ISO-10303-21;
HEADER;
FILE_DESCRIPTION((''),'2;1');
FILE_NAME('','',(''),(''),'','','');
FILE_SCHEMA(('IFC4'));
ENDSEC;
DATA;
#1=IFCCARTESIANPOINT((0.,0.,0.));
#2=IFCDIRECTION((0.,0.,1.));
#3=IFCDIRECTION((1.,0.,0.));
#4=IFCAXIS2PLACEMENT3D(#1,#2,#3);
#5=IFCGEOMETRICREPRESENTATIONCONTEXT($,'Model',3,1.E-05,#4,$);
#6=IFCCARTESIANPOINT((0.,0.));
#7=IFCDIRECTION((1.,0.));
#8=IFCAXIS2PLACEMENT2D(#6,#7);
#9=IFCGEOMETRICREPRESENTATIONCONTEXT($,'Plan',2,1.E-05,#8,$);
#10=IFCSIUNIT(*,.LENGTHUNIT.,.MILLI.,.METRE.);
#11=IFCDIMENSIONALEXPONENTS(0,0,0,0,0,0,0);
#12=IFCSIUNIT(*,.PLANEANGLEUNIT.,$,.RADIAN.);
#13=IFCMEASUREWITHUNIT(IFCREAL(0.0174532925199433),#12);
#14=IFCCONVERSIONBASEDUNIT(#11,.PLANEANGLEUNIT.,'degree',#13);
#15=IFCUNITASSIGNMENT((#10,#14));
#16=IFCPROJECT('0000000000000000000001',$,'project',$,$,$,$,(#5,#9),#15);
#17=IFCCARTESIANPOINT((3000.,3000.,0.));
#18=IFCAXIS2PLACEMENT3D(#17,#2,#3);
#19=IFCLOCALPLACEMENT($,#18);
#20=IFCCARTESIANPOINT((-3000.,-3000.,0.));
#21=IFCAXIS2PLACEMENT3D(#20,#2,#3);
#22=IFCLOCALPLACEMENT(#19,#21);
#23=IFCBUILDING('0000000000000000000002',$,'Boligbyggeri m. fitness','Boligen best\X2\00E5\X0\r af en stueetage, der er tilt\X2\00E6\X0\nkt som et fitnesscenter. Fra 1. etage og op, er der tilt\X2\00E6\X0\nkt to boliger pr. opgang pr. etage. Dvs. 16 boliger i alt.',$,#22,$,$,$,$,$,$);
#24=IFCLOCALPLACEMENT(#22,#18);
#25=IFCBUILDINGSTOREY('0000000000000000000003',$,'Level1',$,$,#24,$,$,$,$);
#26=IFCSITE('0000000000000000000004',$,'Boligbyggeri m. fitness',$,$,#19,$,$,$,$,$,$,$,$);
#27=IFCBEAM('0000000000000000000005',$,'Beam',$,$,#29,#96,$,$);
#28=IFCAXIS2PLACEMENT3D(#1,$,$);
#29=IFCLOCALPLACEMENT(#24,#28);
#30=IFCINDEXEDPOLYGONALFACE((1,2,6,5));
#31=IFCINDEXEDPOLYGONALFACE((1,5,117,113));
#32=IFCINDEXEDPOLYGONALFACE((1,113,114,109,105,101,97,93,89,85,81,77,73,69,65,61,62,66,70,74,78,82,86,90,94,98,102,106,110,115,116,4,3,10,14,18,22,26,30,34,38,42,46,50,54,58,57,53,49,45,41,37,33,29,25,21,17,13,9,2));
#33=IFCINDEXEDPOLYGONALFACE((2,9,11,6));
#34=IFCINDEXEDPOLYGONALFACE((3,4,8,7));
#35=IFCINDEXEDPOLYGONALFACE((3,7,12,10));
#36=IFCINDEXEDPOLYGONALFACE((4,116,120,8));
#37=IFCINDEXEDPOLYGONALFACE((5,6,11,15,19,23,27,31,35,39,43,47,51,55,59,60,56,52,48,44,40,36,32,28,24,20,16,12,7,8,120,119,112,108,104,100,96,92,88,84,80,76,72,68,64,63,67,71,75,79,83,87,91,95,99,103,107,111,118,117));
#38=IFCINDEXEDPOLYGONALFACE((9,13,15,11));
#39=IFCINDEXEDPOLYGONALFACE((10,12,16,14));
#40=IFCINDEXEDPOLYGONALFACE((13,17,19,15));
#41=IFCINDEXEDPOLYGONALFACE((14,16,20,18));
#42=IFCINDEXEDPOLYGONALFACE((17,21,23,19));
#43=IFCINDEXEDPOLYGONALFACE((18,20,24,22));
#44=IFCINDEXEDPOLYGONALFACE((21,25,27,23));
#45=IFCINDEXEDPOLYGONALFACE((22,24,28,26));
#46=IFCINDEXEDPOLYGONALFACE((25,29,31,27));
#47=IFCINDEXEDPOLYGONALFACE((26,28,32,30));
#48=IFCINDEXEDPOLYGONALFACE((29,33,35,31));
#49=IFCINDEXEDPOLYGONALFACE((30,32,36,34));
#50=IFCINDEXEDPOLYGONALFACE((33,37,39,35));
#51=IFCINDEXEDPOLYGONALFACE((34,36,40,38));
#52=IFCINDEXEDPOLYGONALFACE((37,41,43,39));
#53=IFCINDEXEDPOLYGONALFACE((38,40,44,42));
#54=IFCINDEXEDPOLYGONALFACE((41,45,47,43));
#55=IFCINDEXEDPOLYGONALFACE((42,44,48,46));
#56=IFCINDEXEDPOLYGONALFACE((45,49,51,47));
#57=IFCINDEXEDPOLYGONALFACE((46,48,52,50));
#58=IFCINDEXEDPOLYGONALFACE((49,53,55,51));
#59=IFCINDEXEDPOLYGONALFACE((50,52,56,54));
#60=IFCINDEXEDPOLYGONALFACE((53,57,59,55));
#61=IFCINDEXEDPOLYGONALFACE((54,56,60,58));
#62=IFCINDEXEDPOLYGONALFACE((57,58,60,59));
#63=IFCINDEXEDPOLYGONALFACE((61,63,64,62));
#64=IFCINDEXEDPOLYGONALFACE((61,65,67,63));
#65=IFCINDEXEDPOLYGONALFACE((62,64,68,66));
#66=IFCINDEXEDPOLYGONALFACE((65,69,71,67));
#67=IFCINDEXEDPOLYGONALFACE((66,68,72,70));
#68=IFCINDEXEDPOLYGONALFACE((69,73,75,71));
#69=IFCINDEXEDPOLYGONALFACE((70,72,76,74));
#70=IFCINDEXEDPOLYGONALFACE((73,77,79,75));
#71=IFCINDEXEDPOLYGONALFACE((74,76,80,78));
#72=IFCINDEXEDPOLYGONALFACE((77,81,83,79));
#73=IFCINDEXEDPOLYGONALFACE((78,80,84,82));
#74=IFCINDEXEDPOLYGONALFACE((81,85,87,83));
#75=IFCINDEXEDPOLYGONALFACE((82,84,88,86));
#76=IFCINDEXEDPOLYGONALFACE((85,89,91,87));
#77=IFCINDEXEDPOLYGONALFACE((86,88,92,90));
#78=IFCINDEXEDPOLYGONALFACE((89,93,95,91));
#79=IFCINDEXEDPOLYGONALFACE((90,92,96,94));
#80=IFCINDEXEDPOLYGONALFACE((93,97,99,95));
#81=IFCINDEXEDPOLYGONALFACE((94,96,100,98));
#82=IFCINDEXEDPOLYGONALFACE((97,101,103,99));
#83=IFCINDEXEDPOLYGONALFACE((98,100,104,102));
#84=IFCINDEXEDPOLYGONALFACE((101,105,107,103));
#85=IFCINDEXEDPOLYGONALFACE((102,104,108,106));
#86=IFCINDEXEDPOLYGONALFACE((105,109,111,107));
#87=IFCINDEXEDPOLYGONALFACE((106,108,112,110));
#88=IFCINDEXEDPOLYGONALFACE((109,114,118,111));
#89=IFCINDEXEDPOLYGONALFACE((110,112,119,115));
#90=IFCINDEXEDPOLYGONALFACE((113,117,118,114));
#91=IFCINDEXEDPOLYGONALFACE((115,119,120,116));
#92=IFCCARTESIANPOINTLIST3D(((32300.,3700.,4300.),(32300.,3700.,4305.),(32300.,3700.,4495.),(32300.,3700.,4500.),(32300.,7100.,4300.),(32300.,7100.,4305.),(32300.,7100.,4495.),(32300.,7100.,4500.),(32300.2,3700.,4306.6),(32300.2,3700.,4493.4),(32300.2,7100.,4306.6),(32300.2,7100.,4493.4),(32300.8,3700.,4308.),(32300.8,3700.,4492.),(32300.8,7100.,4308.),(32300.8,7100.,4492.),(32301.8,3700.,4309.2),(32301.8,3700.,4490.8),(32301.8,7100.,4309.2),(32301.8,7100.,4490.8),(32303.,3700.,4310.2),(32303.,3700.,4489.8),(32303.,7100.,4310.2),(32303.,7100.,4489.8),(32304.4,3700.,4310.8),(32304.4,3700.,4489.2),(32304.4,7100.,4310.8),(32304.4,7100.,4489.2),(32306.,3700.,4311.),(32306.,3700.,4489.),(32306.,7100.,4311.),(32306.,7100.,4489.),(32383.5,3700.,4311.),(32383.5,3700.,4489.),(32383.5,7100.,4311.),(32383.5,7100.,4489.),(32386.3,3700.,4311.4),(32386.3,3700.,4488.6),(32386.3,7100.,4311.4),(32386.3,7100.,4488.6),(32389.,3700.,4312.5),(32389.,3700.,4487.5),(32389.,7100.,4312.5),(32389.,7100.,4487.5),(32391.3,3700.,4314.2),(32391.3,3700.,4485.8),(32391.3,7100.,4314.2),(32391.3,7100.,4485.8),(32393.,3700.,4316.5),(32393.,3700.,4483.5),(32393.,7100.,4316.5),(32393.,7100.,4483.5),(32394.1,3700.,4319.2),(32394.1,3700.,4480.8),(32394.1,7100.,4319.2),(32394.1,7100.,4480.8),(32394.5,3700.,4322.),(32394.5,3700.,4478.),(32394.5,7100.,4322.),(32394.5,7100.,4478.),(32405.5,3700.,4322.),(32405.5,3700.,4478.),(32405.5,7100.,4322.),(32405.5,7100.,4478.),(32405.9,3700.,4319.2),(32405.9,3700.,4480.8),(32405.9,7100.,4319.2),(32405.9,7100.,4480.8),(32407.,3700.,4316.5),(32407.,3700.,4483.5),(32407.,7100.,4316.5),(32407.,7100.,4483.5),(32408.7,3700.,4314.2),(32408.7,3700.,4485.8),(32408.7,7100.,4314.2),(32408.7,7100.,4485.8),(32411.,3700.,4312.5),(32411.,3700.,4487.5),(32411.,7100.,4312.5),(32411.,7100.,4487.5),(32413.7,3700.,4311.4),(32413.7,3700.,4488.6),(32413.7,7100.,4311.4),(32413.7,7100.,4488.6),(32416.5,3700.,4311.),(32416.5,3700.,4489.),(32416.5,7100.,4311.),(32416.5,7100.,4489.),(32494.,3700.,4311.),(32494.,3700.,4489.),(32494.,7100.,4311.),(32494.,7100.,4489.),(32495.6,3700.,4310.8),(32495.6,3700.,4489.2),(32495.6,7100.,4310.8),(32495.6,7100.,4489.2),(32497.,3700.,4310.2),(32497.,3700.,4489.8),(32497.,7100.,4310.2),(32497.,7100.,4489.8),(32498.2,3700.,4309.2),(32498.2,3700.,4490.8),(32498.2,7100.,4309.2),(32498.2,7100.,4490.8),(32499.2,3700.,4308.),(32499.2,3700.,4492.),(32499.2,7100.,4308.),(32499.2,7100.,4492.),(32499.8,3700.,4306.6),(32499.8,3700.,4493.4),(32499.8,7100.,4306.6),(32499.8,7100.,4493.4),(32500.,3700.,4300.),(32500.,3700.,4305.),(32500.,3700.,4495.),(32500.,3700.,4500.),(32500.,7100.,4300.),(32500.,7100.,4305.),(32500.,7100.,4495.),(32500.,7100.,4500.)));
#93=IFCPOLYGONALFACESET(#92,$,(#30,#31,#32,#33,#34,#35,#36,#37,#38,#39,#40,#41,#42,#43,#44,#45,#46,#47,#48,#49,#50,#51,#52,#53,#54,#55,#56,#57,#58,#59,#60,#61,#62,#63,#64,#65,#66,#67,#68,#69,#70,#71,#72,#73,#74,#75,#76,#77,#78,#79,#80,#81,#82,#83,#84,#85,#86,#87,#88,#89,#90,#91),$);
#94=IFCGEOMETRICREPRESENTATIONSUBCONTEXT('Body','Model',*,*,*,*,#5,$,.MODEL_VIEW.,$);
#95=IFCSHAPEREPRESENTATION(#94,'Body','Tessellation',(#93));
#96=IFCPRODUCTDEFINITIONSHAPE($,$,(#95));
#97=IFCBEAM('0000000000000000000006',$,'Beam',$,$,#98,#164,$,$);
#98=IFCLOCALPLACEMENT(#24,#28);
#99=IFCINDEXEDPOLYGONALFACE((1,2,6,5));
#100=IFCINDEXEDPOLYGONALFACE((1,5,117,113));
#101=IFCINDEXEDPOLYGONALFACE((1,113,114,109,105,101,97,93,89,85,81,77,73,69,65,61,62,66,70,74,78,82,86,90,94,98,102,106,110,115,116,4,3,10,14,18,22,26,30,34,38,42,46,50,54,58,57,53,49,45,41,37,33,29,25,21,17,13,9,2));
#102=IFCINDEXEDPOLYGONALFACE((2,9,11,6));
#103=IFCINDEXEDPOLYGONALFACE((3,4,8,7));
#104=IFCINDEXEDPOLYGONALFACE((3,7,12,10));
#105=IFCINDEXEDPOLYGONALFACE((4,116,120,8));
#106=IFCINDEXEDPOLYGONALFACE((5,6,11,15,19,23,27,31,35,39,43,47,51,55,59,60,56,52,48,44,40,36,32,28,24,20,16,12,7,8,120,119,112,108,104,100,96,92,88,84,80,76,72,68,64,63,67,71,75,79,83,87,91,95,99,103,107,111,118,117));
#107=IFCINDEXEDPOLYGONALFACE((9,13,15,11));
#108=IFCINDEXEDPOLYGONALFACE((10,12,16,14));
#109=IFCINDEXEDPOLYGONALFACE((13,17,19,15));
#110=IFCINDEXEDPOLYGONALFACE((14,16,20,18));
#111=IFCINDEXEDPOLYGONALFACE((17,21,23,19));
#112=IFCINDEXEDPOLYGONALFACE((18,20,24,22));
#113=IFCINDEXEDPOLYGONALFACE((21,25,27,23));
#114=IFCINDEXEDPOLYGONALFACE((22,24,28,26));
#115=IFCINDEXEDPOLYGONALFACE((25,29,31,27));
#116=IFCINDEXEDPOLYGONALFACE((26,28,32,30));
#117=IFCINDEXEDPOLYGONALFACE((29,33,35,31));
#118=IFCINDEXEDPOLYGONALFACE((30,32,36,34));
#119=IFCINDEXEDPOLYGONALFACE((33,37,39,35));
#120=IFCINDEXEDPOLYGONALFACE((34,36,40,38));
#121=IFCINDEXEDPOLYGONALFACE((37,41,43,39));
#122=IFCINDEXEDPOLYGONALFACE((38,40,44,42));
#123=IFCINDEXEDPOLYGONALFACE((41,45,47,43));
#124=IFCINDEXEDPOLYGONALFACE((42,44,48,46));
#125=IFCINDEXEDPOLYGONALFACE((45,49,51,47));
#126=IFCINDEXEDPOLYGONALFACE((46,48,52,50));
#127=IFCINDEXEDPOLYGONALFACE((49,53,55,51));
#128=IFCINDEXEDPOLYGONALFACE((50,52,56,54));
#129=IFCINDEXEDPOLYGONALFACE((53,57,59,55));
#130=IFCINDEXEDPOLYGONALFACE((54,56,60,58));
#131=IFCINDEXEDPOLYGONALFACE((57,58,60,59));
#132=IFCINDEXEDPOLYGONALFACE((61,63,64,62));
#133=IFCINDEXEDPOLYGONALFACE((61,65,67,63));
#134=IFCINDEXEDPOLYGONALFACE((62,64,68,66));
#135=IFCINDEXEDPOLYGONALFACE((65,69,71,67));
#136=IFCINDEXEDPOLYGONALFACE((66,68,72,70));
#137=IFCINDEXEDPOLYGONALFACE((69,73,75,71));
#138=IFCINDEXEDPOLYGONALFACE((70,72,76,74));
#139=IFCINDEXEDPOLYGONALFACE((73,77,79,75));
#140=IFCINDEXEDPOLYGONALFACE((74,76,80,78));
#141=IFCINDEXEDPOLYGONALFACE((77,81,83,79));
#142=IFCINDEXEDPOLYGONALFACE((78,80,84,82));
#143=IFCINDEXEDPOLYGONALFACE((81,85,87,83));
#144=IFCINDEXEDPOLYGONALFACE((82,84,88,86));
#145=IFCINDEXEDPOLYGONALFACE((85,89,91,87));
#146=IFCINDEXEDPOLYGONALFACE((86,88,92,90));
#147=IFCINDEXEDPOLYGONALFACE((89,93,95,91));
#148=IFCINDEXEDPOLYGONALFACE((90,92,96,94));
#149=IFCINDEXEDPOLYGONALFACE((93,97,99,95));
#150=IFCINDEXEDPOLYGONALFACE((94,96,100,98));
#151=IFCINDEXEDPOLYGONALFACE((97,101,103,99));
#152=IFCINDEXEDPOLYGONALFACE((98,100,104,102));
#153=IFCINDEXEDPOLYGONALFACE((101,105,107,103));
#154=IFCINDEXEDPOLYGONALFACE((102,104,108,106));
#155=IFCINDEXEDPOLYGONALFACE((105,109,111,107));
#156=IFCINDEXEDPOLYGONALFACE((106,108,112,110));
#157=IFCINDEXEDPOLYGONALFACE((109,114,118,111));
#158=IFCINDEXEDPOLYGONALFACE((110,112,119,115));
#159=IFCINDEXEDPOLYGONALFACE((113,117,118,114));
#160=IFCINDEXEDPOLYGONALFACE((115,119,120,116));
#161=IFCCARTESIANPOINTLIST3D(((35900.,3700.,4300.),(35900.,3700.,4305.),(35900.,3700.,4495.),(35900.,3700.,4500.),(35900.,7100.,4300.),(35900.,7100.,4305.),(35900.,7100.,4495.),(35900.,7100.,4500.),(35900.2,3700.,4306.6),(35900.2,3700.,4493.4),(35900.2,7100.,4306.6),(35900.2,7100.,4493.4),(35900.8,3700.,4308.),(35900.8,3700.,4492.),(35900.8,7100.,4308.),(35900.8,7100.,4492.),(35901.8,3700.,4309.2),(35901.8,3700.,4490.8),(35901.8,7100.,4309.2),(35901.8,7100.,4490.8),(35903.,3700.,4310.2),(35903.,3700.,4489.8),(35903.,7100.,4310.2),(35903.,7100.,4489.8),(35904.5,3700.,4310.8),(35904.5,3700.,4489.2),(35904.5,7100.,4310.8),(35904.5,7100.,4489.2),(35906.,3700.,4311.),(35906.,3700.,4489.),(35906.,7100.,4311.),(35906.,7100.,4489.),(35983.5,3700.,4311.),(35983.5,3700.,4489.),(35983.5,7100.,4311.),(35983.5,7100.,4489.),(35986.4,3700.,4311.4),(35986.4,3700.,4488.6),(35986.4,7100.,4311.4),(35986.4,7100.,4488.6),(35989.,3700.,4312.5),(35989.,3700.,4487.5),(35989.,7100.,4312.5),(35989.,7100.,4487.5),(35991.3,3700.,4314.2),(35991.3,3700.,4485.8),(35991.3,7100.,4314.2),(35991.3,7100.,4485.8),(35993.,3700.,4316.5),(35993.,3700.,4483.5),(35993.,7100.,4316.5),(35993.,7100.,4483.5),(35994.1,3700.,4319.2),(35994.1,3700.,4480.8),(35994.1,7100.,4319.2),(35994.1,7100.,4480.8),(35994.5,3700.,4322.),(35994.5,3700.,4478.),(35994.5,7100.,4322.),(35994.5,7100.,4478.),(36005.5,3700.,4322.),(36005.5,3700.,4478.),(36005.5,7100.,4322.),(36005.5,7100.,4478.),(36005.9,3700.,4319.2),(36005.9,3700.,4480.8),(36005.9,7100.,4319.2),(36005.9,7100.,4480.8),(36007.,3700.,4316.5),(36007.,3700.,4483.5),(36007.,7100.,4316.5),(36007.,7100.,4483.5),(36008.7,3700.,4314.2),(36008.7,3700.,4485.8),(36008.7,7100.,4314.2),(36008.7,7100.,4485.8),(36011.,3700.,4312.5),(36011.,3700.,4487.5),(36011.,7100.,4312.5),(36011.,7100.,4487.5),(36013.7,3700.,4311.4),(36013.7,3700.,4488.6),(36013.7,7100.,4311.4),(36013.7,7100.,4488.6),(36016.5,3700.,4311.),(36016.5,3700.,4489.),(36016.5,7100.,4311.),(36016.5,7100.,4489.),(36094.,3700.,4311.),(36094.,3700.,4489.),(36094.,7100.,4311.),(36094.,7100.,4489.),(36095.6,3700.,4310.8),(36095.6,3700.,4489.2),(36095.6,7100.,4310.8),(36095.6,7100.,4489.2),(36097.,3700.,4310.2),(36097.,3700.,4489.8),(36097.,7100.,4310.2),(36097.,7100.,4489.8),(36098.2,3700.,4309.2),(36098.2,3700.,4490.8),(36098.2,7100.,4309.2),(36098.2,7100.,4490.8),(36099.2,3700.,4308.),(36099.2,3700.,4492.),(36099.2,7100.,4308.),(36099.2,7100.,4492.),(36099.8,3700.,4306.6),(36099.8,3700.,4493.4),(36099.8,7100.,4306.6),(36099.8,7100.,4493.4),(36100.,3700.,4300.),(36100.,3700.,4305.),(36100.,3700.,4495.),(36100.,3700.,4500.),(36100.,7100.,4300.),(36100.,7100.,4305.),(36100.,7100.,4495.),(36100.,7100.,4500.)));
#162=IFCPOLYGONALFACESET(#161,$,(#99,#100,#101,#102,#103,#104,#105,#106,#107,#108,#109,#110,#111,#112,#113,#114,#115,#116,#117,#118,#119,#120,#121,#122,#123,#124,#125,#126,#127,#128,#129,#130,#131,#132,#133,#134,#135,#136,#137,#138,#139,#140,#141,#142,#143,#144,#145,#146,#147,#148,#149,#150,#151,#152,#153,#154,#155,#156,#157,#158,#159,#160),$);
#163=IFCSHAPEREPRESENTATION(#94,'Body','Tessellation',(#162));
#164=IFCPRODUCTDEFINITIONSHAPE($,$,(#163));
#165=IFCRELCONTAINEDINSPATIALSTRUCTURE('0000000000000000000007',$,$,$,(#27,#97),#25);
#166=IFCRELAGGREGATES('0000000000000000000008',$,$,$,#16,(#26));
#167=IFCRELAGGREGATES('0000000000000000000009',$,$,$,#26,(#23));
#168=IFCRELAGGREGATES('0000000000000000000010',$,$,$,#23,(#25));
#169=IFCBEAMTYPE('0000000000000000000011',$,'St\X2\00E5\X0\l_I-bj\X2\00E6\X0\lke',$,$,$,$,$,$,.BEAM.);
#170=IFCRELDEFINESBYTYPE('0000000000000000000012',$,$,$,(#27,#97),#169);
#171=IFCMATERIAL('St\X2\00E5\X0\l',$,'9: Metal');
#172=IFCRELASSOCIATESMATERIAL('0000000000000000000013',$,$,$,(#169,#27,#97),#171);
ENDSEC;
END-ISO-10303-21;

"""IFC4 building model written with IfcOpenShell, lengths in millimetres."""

from ifc_helpers import new_model, entity, si_unit, converted_unit, frame, origin_with_axes, origin_2d_with_axis, place, context, subcontext, project, spatial, i_section, extrude, material, material_profile, profile_set, profile_usage, type_object, element, save


model = new_model("IFC4")

# Units and contexts
model_context = context("Model", 3, precision=1e-05, world=origin_with_axes())
plan_context = context("Plan", 2, precision=1e-05, world=origin_2d_with_axis())
body_context = subcontext(model_context, "Body", "Model", "MODEL_VIEW")
ifc_project = project(units=[si_unit("LENGTHUNIT", "METRE", prefix="MILLI"), converted_unit("PLANEANGLEUNIT", "degree", entity("IfcReal", 0.0174532925199433), si_unit("PLANEANGLEUNIT", "RADIAN"), dimensions=[0, 0, 0, 0, 0, 0, 0])], contexts=[model_context, plan_context])

# Site, building, storey
site_placement = place(None, frame((3000.0, 3000.0, 0.0), z_axis=(0.0, 0.0, 1.0), x_axis=(1.0, 0.0, 0.0)))
site = spatial("IfcSite", under=ifc_project, at=site_placement, Name="Boligbyggeri m. fitness")
building_placement = place(site_placement, frame((-3000.0, -3000.0, 0.0), z_axis=(0.0, 0.0, 1.0), x_axis=(1.0, 0.0, 0.0)))
building = spatial("IfcBuilding", under=site, at=building_placement, Name="Boligbyggeri m. fitness", Description="Boligen består af en stueetage, der er tiltænkt som et fitnesscenter. Fra 1. etage og op, er der tiltænkt to boliger pr. opgang pr. etage. Dvs. 16 boliger i alt.")
storey_placement = place(building_placement, frame((3000.0, 3000.0, 0.0), z_axis=(0.0, 0.0, 1.0), x_axis=(1.0, 0.0, 0.0)))
storey = spatial("IfcBuildingStorey", under=building, at=storey_placement, Name="Level1")

# Beams
ifc_material_1 = material(Name="Stål", Category="9: Metal")
ifc_material_profile_1 = material_profile(ifc_material_1, i_section(OverallWidth=200.0, OverallDepth=200.0, WebThickness=11.0, FlangeThickness=11.0, FilletRadius=11.0, FlangeEdgeRadius=6.0), Name="Stål", Category="9: Metal")
ifc_profile_set_1 = profile_set([ifc_material_profile_1], Name="NY_I-Profil")
beam_type = type_object("IfcBeamType", Name="Stål_I-bjælke", PredefinedType="BEAM", material=ifc_profile_set_1)
ifc_profile_usage_1 = profile_usage(ifc_profile_set_1, cardinal=9)
beam_1_placement = place(storey_placement, frame((32500.0, 3700.0, 4500.0), z_axis=(0.0, 1.0, 0.0), x_axis=(-1.0, 0.0, 0.0)))
element("IfcBeam", 1, at=beam_1_placement, inside=storey, type_object=beam_type, material=ifc_profile_usage_1, Name="Beam", context=body_context, shape_type="SweptSolid", body=[
    extrude(i_section(OverallWidth=200.0, OverallDepth=200.0, WebThickness=11.0, FlangeThickness=11.0, FilletRadius=11.0, FlangeEdgeRadius=6.0), frame((100.0, -100.0, 0.0), z_axis=(0.0, 0.0, 1.0), x_axis=(1.0, 0.0, 0.0)), (0.0, 0.0, 1.0), 3400.0),
])
ifc_profile_usage_2 = profile_usage(ifc_profile_set_1, cardinal=9)
beam_2_placement = place(storey_placement, frame((36100.0, 3700.0, 4500.0), z_axis=(0.0, 1.0, 0.0), x_axis=(-1.0, 0.0, 0.0)))
element("IfcBeam", 2, at=beam_2_placement, inside=storey, type_object=beam_type, material=ifc_profile_usage_2, Name="Beam", context=body_context, shape_type="SweptSolid", body=[
    extrude(i_section(OverallWidth=200.0, OverallDepth=200.0, WebThickness=11.0, FlangeThickness=11.0, FilletRadius=11.0, FlangeEdgeRadius=6.0), frame((100.0, -100.0, 0.0), z_axis=(0.0, 0.0, 1.0), x_axis=(1.0, 0.0, 0.0)), (0.0, 0.0, 1.0), 3400.0),
])

save(model, "model.ifc")
